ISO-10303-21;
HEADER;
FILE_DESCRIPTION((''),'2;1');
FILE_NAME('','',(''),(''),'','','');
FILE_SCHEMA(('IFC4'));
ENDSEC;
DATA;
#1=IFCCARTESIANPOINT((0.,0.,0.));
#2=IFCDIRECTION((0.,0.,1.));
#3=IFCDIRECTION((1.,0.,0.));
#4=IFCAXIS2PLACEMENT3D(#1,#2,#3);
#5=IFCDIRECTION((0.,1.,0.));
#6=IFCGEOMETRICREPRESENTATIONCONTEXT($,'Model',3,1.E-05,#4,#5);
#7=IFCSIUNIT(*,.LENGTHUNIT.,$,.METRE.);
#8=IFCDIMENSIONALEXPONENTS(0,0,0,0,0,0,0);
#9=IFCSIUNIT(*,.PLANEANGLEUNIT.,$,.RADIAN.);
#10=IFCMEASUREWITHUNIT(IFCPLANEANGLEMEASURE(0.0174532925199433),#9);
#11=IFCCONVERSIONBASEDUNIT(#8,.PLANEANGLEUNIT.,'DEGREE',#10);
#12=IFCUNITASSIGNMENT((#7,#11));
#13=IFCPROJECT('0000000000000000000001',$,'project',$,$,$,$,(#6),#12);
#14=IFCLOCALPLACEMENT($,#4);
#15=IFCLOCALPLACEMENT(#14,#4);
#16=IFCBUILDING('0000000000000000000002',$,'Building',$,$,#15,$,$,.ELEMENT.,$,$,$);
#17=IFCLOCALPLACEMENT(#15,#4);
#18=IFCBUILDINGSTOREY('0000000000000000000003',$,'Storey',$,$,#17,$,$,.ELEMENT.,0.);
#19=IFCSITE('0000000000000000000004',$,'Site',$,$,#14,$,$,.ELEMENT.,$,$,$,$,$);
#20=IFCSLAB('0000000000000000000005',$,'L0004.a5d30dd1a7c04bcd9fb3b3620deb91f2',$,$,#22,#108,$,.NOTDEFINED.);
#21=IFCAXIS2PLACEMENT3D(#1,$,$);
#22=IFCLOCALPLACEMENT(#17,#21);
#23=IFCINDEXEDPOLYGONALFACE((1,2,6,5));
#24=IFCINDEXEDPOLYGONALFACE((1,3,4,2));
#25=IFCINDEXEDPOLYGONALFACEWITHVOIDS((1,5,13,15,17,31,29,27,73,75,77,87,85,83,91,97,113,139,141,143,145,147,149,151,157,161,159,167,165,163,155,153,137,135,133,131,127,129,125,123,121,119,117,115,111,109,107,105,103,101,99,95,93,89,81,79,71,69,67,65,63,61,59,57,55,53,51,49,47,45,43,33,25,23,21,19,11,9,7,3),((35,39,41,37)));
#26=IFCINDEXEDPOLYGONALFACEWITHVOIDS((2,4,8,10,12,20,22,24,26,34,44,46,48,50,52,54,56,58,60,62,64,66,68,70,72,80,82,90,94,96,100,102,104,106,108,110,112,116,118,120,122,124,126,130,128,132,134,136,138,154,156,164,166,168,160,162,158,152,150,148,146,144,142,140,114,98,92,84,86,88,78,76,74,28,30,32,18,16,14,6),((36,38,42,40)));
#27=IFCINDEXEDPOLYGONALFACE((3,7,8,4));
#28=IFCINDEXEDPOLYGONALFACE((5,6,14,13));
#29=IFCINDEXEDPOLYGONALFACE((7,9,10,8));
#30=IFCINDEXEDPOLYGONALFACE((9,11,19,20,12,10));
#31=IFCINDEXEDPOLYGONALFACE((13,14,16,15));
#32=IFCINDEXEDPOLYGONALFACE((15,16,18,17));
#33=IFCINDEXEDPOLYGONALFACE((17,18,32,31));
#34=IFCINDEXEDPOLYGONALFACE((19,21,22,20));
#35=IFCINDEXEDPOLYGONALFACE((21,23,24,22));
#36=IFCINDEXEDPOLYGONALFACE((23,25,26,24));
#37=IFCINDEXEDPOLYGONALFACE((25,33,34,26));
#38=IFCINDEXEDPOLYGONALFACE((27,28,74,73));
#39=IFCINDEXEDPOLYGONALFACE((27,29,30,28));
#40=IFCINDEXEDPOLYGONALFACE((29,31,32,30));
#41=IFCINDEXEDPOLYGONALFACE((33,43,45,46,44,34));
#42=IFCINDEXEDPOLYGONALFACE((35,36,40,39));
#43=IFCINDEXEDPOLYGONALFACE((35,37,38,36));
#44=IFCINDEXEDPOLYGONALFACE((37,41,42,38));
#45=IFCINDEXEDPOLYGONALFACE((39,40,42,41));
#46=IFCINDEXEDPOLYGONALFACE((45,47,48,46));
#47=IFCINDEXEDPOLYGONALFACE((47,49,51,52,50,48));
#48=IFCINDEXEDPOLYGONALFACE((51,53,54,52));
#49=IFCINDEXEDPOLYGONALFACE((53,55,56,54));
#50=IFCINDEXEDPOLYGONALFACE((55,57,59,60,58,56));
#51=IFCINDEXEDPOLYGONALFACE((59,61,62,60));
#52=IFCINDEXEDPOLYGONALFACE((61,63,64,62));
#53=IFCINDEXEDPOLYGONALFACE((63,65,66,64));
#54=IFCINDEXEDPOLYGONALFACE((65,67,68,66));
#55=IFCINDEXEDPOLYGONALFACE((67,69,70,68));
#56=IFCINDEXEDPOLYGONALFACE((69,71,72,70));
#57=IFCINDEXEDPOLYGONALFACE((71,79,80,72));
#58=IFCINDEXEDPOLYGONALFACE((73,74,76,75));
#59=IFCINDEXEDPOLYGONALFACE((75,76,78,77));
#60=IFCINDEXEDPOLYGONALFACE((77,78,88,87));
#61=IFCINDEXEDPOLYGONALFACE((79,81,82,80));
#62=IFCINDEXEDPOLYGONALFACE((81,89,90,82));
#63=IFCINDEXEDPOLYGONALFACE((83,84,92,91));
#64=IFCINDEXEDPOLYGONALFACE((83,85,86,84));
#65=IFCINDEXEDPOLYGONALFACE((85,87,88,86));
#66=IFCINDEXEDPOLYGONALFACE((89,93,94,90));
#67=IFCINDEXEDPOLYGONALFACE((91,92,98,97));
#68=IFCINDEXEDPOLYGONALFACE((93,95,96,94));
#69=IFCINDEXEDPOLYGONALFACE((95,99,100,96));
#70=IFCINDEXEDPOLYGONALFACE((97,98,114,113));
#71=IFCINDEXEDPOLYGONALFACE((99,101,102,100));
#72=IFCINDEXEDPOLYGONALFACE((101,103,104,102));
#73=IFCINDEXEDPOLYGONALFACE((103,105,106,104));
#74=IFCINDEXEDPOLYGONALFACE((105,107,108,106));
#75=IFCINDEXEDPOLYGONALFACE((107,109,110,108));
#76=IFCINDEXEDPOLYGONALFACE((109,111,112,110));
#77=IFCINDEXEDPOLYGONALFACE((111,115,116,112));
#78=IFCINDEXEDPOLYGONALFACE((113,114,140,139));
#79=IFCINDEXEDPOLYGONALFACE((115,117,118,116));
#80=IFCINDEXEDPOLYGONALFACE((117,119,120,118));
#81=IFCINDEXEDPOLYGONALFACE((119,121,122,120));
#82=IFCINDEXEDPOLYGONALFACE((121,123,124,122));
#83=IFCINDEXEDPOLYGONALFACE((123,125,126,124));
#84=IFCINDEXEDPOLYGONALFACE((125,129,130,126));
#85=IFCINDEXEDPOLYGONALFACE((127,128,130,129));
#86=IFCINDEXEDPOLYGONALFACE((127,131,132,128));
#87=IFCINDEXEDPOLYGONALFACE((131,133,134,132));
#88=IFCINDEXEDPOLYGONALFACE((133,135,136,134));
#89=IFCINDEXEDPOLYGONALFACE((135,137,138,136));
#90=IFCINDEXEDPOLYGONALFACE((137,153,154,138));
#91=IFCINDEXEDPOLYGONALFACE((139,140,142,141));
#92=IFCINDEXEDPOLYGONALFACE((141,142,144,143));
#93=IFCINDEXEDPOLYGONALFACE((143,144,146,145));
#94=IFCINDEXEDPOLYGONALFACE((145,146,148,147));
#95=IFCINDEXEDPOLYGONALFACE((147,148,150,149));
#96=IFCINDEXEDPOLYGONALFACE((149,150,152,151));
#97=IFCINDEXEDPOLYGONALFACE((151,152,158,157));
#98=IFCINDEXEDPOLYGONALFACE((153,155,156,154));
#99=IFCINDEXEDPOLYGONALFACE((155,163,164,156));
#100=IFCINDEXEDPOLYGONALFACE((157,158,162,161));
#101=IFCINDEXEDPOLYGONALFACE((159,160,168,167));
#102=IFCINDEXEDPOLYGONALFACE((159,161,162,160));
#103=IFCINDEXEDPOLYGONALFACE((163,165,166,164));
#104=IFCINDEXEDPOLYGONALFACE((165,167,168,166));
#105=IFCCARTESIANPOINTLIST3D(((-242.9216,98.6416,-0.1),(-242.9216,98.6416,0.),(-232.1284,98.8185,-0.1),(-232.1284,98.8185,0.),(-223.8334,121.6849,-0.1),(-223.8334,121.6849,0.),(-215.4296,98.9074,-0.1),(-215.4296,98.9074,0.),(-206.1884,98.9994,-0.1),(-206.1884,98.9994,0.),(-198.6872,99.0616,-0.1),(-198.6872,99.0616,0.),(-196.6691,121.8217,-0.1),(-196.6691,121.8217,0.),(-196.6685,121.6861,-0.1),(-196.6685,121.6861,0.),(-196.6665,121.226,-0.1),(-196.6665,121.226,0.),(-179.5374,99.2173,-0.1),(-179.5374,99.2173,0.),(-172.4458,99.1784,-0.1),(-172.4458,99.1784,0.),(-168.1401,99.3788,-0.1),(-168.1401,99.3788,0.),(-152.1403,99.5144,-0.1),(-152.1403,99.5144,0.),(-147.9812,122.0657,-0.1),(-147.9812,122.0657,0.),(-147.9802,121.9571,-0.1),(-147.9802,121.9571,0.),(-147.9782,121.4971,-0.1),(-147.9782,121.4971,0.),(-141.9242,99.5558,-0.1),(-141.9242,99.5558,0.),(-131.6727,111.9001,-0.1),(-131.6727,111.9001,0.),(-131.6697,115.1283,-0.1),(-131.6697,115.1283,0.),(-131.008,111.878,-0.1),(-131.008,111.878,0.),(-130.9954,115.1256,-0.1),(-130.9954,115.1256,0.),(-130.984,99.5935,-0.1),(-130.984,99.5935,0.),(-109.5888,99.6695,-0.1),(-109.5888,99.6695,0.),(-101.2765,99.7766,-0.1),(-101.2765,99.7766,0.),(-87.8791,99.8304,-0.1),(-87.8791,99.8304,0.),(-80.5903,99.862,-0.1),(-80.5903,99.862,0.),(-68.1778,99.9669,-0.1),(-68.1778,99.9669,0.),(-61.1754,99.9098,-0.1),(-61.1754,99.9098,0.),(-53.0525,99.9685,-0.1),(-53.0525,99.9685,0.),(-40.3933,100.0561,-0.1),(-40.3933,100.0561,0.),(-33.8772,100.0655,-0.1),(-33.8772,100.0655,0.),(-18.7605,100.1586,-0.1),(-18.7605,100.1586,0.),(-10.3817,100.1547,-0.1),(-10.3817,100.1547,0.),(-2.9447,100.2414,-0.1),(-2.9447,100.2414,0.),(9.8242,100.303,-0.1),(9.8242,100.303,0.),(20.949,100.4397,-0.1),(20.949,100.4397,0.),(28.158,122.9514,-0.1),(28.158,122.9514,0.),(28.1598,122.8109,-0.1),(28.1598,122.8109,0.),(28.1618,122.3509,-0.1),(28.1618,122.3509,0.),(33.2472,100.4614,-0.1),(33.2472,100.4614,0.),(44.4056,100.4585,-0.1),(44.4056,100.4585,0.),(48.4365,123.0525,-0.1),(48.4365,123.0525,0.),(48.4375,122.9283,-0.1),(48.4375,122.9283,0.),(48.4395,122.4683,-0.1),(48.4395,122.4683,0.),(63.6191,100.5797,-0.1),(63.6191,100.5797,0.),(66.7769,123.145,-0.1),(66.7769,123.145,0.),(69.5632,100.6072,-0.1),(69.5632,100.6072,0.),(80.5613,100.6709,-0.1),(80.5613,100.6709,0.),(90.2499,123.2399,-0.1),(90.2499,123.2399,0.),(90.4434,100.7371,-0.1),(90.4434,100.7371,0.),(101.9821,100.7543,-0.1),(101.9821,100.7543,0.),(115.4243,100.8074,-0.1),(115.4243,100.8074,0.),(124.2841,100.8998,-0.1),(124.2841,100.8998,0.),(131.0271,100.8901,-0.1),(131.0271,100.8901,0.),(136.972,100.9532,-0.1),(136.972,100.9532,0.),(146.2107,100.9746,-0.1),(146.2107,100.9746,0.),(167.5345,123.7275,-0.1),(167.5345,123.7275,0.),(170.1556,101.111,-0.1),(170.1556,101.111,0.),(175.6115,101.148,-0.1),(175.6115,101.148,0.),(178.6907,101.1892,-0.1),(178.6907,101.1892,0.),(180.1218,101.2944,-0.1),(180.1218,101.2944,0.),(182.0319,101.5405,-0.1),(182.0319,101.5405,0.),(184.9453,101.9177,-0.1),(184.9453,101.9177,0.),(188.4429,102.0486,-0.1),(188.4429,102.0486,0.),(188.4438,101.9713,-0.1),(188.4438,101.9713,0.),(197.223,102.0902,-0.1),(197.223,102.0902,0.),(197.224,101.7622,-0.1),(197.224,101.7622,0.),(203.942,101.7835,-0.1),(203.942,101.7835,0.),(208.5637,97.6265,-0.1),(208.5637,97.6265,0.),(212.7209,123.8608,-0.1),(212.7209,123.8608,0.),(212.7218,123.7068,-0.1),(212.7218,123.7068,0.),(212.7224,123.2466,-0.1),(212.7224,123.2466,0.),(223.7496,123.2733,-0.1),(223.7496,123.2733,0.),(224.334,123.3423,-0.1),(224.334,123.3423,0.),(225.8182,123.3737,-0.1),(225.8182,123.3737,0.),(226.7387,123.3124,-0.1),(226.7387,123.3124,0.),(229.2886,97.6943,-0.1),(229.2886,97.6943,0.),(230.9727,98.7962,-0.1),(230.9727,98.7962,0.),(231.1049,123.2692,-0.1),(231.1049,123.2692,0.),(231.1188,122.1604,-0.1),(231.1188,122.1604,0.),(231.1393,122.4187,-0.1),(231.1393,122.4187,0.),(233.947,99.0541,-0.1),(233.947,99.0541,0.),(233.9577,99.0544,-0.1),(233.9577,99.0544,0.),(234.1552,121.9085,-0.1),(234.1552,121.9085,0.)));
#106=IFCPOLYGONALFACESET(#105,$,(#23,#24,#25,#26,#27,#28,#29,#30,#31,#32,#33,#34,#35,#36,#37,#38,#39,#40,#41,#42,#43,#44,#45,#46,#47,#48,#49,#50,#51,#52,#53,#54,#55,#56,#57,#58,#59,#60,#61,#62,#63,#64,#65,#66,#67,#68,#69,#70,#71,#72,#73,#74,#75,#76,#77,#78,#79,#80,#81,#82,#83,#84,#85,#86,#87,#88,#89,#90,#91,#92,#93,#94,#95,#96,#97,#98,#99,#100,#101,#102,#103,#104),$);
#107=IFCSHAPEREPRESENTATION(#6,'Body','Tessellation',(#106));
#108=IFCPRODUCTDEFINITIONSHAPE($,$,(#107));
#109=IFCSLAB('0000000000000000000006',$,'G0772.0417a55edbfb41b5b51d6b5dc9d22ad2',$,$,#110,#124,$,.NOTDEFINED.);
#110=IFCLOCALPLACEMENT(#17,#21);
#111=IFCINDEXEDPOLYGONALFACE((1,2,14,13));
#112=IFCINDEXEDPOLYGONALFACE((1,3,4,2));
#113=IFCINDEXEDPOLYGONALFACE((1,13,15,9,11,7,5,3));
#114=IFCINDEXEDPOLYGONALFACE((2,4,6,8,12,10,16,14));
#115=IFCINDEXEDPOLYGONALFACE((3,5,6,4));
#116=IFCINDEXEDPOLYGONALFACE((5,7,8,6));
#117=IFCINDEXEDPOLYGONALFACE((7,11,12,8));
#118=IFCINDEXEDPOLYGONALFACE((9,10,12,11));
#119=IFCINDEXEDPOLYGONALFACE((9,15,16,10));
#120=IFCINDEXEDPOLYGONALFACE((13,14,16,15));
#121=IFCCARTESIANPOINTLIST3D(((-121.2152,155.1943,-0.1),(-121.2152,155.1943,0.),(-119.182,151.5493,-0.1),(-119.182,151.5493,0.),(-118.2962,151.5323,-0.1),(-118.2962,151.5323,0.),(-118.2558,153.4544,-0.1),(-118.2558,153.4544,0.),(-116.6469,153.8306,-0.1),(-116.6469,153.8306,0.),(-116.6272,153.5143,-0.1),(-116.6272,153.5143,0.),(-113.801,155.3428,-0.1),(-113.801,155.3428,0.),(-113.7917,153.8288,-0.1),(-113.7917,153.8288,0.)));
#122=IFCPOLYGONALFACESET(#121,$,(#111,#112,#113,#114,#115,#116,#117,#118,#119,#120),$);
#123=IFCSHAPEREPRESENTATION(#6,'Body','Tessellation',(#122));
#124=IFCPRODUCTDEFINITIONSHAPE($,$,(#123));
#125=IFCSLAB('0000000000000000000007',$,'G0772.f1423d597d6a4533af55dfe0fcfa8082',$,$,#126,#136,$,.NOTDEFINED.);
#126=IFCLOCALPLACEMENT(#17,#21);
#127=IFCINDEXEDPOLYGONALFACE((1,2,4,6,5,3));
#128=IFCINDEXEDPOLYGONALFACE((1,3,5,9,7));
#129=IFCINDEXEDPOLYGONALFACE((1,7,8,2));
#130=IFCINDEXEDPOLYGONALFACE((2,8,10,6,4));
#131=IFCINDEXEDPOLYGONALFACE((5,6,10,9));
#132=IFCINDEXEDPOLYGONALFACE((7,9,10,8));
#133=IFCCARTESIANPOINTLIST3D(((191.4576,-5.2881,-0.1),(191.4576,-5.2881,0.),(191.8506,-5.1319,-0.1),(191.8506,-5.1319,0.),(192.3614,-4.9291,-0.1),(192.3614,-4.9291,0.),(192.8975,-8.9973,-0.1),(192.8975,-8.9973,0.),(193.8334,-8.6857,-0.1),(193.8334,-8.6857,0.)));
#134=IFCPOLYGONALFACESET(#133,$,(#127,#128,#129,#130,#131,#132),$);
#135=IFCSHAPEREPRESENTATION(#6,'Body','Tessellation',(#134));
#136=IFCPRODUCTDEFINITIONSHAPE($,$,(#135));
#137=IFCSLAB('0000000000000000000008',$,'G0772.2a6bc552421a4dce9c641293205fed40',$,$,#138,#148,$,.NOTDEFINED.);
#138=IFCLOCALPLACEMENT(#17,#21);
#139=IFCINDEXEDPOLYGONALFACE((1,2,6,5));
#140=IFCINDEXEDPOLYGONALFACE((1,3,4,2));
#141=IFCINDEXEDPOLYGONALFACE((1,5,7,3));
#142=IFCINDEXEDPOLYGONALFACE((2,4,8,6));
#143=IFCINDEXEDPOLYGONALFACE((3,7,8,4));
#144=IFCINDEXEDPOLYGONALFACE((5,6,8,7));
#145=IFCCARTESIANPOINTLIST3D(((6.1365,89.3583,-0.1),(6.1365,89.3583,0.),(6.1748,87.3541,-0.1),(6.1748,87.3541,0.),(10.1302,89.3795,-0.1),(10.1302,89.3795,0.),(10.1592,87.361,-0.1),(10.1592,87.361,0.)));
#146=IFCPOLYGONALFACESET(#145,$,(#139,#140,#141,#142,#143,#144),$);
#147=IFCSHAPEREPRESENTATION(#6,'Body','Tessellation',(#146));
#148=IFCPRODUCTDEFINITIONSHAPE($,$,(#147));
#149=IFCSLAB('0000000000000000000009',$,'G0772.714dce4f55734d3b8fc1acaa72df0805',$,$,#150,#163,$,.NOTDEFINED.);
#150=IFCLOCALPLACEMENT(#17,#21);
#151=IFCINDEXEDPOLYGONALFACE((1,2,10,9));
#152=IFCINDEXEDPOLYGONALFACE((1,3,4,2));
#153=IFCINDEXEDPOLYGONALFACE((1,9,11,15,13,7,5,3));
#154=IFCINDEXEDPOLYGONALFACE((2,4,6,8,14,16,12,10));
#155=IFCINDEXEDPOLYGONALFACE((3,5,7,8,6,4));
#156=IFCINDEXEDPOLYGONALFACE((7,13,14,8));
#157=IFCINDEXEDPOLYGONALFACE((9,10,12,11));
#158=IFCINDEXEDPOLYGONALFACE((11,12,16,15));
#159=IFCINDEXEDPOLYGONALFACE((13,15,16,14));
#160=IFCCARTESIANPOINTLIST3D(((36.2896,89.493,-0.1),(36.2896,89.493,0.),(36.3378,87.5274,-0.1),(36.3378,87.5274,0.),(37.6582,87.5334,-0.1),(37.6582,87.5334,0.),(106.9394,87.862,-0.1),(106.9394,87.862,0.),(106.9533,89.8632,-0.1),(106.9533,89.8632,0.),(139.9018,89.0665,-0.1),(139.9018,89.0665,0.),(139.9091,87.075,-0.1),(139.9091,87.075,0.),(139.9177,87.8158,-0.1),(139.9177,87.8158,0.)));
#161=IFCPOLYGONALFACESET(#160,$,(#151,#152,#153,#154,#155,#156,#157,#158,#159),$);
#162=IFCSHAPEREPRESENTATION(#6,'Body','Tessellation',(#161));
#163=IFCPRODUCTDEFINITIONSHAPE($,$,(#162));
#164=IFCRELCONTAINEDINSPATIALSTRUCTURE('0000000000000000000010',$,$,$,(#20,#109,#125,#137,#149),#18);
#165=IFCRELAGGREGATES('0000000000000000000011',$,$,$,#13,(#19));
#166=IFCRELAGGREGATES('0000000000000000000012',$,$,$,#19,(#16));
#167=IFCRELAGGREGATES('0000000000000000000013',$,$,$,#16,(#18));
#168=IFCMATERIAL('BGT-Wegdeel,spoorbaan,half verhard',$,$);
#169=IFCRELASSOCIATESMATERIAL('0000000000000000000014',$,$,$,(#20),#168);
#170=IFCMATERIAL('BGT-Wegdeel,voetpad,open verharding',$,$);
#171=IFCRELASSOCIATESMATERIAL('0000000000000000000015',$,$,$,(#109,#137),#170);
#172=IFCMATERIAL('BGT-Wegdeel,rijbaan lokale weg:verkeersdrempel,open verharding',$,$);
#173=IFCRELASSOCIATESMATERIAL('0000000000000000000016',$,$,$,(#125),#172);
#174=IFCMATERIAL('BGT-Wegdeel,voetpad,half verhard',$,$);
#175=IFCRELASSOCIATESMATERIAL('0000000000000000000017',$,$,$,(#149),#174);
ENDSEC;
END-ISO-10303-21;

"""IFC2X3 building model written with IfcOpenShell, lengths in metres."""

from ifc_helpers import new_model, entity, si_unit, converted_unit, direction, frame, origin_with_axes, place, context, project, spatial, polyline, outline, extrude, material, element, save


model = new_model("IFC2X3")

# Units and contexts
model_context = context("Model", 3, precision=1e-05, world=origin_with_axes(), true_north=direction((0.0, 1.0, 0.0)))
ifc_project = project(units=[si_unit("LENGTHUNIT", "METRE"), converted_unit("PLANEANGLEUNIT", "DEGREE", entity("IfcPlaneAngleMeasure", 0.0174532925199433), si_unit("PLANEANGLEUNIT", "RADIAN"), dimensions=[0, 0, 0, 0, 0, 0, 0])], contexts=[model_context])

# Site, building, storey
site_placement = place(None, origin_with_axes())
site = spatial("IfcSite", under=ifc_project, at=site_placement, Name="Site", CompositionType="ELEMENT")
building_placement = place(site_placement, origin_with_axes())
building = spatial("IfcBuilding", under=site, at=building_placement, Name="Building", CompositionType="ELEMENT")
storey_placement = place(building_placement, origin_with_axes())
storey = spatial("IfcBuildingStorey", under=building, at=storey_placement, Name="Storey", CompositionType="ELEMENT", Elevation=0.0)

# Slabs
ifc_material_1 = material(Name="BGT-Wegdeel,voetpad,half verhard")
ifc_material_2 = material(Name="BGT-Wegdeel,voetpad,open verharding")
ifc_material_3 = material(Name="BGT-Wegdeel,spoorbaan,half verhard")
slab_1_placement = place(storey_placement, frame((0.0, 0.0, -0.1), z_axis=(0.0, 0.0, 1.0), x_axis=(1.0, 0.0, 0.0)))
element("IfcSlab", 1, at=slab_1_placement, inside=storey, material=ifc_material_3, Name="L0004.a5d30dd1a7c04bcd9fb3b3620deb91f2", PredefinedType="NOTDEFINED", context=model_context, shape_type="SweptSolid", body=[
    extrude(outline(polyline([(-196.6691, 121.8217), (-196.6685, 121.6861), (-196.6665, 121.226), (-147.9782, 121.4971), (-147.9802, 121.9571), (-147.9812, 122.0657), (28.158, 122.9514), (28.1598, 122.8109), (28.1618, 122.3509), (48.4395, 122.4683), (48.4375, 122.9283), (48.4365, 123.0525), (66.7769, 123.145), (90.2499, 123.2399), (167.5345, 123.7275), (212.7209, 123.8608), (212.7218, 123.7068), (212.7224, 123.2466), (223.7496, 123.2733), (224.334, 123.3423), (225.8182, 123.3737), (226.7387, 123.3124), (231.1049, 123.2692), (231.1393, 122.4187), (231.1188, 122.1604), (234.1552, 121.9085), (233.9577, 99.0544), (233.947, 99.0541), (230.9727, 98.7962), (229.2886, 97.6943), (208.5637, 97.6265), (203.942, 101.7835), (197.224, 101.7622), (197.223, 102.0902), (188.4429, 102.0486), (188.4438, 101.9713), (184.9453, 101.9177), (182.0319, 101.5405), (180.1218, 101.2944), (178.6907, 101.1892), (175.6115, 101.148), (170.1556, 101.111), (146.2107, 100.9746), (136.972, 100.9532), (131.0271, 100.8901), (124.2841, 100.8998), (115.4243, 100.8074), (101.9821, 100.7543), (90.4434, 100.7371), (80.5613, 100.6709), (69.5632, 100.6072), (63.6191, 100.5797), (44.4056, 100.4585), (33.2472, 100.4614), (20.949, 100.4397), (9.8242, 100.303), (-2.9447, 100.2414), (-10.3817, 100.1547), (-18.7605, 100.1586), (-33.8772, 100.0655), (-40.3933, 100.0561), (-53.0525, 99.9685), (-61.1754, 99.9098), (-68.1778, 99.9669), (-80.5903, 99.862), (-87.8791, 99.8304), (-101.2765, 99.7766), (-109.5888, 99.6695), (-130.984, 99.5935), (-141.9242, 99.5558), (-152.1403, 99.5144), (-168.1401, 99.3788), (-172.4458, 99.1784), (-179.5374, 99.2173), (-198.6872, 99.0616), (-206.1884, 98.9994), (-215.4296, 98.9074), (-232.1284, 98.8185), (-242.9216, 98.6416), (-223.8334, 121.6849), (-196.6691, 121.8217)]), holes=[polyline([(-130.9954, 115.1256), (-131.6697, 115.1283), (-131.6727, 111.9001), (-131.008, 111.878), (-130.9954, 115.1256)])]), origin_with_axes(), (0.0, 0.0, 1.0), 0.1),
])
slab_2_placement = place(storey_placement, frame((0.0, 0.0, -0.1), z_axis=(0.0, 0.0, 1.0), x_axis=(1.0, 0.0, 0.0)))
element("IfcSlab", 2, at=slab_2_placement, inside=storey, material=ifc_material_2, Name="G0772.0417a55edbfb41b5b51d6b5dc9d22ad2", PredefinedType="NOTDEFINED", context=model_context, shape_type="SweptSolid", body=[
    extrude(outline(polyline([(-119.182, 151.5493), (-121.2152, 155.1943), (-113.801, 155.3428), (-113.7917, 153.8288), (-116.6469, 153.8306), (-116.6272, 153.5143), (-118.2558, 153.4544), (-118.2962, 151.5323), (-119.182, 151.5493)])), origin_with_axes(), (0.0, 0.0, 1.0), 0.1),
])
ifc_material_4 = material(Name="BGT-Wegdeel,rijbaan lokale weg:verkeersdrempel,open verharding")
slab_3_placement = place(storey_placement, frame((0.0, 0.0, -0.1), z_axis=(0.0, 0.0, 1.0), x_axis=(1.0, 0.0, 0.0)))
element("IfcSlab", 3, at=slab_3_placement, inside=storey, material=ifc_material_4, Name="G0772.f1423d597d6a4533af55dfe0fcfa8082", PredefinedType="NOTDEFINED", context=model_context, shape_type="SweptSolid", body=[
    extrude(outline(polyline([(193.8334, -8.6857), (192.8975, -8.9973), (191.4576, -5.2881), (191.8506, -5.1319), (192.3614, -4.9291), (193.8334, -8.6857)])), origin_with_axes(), (0.0, 0.0, 1.0), 0.1),
])
slab_4_placement = place(storey_placement, frame((0.0, 0.0, -0.1), z_axis=(0.0, 0.0, 1.0), x_axis=(1.0, 0.0, 0.0)))
element("IfcSlab", 4, at=slab_4_placement, inside=storey, material=ifc_material_2, Name="G0772.2a6bc552421a4dce9c641293205fed40", PredefinedType="NOTDEFINED", context=model_context, shape_type="SweptSolid", body=[
    extrude(outline(polyline([(10.1302, 89.3795), (10.1592, 87.361), (6.1748, 87.3541), (6.1365, 89.3583), (10.1302, 89.3795)])), origin_with_axes(), (0.0, 0.0, 1.0), 0.1),
])
slab_5_placement = place(storey_placement, frame((0.0, 0.0, -0.1), z_axis=(0.0, 0.0, 1.0), x_axis=(1.0, 0.0, 0.0)))
element("IfcSlab", 5, at=slab_5_placement, inside=storey, material=ifc_material_1, Name="G0772.714dce4f55734d3b8fc1acaa72df0805", PredefinedType="NOTDEFINED", context=model_context, shape_type="SweptSolid", body=[
    extrude(outline(polyline([(106.9533, 89.8632), (139.9018, 89.0665), (139.9177, 87.8158), (139.9091, 87.075), (106.9394, 87.862), (37.6582, 87.5334), (36.3378, 87.5274), (36.2896, 89.493), (106.9533, 89.8632)])), origin_with_axes(), (0.0, 0.0, 1.0), 0.1),
])

save(model, "model.ifc")
